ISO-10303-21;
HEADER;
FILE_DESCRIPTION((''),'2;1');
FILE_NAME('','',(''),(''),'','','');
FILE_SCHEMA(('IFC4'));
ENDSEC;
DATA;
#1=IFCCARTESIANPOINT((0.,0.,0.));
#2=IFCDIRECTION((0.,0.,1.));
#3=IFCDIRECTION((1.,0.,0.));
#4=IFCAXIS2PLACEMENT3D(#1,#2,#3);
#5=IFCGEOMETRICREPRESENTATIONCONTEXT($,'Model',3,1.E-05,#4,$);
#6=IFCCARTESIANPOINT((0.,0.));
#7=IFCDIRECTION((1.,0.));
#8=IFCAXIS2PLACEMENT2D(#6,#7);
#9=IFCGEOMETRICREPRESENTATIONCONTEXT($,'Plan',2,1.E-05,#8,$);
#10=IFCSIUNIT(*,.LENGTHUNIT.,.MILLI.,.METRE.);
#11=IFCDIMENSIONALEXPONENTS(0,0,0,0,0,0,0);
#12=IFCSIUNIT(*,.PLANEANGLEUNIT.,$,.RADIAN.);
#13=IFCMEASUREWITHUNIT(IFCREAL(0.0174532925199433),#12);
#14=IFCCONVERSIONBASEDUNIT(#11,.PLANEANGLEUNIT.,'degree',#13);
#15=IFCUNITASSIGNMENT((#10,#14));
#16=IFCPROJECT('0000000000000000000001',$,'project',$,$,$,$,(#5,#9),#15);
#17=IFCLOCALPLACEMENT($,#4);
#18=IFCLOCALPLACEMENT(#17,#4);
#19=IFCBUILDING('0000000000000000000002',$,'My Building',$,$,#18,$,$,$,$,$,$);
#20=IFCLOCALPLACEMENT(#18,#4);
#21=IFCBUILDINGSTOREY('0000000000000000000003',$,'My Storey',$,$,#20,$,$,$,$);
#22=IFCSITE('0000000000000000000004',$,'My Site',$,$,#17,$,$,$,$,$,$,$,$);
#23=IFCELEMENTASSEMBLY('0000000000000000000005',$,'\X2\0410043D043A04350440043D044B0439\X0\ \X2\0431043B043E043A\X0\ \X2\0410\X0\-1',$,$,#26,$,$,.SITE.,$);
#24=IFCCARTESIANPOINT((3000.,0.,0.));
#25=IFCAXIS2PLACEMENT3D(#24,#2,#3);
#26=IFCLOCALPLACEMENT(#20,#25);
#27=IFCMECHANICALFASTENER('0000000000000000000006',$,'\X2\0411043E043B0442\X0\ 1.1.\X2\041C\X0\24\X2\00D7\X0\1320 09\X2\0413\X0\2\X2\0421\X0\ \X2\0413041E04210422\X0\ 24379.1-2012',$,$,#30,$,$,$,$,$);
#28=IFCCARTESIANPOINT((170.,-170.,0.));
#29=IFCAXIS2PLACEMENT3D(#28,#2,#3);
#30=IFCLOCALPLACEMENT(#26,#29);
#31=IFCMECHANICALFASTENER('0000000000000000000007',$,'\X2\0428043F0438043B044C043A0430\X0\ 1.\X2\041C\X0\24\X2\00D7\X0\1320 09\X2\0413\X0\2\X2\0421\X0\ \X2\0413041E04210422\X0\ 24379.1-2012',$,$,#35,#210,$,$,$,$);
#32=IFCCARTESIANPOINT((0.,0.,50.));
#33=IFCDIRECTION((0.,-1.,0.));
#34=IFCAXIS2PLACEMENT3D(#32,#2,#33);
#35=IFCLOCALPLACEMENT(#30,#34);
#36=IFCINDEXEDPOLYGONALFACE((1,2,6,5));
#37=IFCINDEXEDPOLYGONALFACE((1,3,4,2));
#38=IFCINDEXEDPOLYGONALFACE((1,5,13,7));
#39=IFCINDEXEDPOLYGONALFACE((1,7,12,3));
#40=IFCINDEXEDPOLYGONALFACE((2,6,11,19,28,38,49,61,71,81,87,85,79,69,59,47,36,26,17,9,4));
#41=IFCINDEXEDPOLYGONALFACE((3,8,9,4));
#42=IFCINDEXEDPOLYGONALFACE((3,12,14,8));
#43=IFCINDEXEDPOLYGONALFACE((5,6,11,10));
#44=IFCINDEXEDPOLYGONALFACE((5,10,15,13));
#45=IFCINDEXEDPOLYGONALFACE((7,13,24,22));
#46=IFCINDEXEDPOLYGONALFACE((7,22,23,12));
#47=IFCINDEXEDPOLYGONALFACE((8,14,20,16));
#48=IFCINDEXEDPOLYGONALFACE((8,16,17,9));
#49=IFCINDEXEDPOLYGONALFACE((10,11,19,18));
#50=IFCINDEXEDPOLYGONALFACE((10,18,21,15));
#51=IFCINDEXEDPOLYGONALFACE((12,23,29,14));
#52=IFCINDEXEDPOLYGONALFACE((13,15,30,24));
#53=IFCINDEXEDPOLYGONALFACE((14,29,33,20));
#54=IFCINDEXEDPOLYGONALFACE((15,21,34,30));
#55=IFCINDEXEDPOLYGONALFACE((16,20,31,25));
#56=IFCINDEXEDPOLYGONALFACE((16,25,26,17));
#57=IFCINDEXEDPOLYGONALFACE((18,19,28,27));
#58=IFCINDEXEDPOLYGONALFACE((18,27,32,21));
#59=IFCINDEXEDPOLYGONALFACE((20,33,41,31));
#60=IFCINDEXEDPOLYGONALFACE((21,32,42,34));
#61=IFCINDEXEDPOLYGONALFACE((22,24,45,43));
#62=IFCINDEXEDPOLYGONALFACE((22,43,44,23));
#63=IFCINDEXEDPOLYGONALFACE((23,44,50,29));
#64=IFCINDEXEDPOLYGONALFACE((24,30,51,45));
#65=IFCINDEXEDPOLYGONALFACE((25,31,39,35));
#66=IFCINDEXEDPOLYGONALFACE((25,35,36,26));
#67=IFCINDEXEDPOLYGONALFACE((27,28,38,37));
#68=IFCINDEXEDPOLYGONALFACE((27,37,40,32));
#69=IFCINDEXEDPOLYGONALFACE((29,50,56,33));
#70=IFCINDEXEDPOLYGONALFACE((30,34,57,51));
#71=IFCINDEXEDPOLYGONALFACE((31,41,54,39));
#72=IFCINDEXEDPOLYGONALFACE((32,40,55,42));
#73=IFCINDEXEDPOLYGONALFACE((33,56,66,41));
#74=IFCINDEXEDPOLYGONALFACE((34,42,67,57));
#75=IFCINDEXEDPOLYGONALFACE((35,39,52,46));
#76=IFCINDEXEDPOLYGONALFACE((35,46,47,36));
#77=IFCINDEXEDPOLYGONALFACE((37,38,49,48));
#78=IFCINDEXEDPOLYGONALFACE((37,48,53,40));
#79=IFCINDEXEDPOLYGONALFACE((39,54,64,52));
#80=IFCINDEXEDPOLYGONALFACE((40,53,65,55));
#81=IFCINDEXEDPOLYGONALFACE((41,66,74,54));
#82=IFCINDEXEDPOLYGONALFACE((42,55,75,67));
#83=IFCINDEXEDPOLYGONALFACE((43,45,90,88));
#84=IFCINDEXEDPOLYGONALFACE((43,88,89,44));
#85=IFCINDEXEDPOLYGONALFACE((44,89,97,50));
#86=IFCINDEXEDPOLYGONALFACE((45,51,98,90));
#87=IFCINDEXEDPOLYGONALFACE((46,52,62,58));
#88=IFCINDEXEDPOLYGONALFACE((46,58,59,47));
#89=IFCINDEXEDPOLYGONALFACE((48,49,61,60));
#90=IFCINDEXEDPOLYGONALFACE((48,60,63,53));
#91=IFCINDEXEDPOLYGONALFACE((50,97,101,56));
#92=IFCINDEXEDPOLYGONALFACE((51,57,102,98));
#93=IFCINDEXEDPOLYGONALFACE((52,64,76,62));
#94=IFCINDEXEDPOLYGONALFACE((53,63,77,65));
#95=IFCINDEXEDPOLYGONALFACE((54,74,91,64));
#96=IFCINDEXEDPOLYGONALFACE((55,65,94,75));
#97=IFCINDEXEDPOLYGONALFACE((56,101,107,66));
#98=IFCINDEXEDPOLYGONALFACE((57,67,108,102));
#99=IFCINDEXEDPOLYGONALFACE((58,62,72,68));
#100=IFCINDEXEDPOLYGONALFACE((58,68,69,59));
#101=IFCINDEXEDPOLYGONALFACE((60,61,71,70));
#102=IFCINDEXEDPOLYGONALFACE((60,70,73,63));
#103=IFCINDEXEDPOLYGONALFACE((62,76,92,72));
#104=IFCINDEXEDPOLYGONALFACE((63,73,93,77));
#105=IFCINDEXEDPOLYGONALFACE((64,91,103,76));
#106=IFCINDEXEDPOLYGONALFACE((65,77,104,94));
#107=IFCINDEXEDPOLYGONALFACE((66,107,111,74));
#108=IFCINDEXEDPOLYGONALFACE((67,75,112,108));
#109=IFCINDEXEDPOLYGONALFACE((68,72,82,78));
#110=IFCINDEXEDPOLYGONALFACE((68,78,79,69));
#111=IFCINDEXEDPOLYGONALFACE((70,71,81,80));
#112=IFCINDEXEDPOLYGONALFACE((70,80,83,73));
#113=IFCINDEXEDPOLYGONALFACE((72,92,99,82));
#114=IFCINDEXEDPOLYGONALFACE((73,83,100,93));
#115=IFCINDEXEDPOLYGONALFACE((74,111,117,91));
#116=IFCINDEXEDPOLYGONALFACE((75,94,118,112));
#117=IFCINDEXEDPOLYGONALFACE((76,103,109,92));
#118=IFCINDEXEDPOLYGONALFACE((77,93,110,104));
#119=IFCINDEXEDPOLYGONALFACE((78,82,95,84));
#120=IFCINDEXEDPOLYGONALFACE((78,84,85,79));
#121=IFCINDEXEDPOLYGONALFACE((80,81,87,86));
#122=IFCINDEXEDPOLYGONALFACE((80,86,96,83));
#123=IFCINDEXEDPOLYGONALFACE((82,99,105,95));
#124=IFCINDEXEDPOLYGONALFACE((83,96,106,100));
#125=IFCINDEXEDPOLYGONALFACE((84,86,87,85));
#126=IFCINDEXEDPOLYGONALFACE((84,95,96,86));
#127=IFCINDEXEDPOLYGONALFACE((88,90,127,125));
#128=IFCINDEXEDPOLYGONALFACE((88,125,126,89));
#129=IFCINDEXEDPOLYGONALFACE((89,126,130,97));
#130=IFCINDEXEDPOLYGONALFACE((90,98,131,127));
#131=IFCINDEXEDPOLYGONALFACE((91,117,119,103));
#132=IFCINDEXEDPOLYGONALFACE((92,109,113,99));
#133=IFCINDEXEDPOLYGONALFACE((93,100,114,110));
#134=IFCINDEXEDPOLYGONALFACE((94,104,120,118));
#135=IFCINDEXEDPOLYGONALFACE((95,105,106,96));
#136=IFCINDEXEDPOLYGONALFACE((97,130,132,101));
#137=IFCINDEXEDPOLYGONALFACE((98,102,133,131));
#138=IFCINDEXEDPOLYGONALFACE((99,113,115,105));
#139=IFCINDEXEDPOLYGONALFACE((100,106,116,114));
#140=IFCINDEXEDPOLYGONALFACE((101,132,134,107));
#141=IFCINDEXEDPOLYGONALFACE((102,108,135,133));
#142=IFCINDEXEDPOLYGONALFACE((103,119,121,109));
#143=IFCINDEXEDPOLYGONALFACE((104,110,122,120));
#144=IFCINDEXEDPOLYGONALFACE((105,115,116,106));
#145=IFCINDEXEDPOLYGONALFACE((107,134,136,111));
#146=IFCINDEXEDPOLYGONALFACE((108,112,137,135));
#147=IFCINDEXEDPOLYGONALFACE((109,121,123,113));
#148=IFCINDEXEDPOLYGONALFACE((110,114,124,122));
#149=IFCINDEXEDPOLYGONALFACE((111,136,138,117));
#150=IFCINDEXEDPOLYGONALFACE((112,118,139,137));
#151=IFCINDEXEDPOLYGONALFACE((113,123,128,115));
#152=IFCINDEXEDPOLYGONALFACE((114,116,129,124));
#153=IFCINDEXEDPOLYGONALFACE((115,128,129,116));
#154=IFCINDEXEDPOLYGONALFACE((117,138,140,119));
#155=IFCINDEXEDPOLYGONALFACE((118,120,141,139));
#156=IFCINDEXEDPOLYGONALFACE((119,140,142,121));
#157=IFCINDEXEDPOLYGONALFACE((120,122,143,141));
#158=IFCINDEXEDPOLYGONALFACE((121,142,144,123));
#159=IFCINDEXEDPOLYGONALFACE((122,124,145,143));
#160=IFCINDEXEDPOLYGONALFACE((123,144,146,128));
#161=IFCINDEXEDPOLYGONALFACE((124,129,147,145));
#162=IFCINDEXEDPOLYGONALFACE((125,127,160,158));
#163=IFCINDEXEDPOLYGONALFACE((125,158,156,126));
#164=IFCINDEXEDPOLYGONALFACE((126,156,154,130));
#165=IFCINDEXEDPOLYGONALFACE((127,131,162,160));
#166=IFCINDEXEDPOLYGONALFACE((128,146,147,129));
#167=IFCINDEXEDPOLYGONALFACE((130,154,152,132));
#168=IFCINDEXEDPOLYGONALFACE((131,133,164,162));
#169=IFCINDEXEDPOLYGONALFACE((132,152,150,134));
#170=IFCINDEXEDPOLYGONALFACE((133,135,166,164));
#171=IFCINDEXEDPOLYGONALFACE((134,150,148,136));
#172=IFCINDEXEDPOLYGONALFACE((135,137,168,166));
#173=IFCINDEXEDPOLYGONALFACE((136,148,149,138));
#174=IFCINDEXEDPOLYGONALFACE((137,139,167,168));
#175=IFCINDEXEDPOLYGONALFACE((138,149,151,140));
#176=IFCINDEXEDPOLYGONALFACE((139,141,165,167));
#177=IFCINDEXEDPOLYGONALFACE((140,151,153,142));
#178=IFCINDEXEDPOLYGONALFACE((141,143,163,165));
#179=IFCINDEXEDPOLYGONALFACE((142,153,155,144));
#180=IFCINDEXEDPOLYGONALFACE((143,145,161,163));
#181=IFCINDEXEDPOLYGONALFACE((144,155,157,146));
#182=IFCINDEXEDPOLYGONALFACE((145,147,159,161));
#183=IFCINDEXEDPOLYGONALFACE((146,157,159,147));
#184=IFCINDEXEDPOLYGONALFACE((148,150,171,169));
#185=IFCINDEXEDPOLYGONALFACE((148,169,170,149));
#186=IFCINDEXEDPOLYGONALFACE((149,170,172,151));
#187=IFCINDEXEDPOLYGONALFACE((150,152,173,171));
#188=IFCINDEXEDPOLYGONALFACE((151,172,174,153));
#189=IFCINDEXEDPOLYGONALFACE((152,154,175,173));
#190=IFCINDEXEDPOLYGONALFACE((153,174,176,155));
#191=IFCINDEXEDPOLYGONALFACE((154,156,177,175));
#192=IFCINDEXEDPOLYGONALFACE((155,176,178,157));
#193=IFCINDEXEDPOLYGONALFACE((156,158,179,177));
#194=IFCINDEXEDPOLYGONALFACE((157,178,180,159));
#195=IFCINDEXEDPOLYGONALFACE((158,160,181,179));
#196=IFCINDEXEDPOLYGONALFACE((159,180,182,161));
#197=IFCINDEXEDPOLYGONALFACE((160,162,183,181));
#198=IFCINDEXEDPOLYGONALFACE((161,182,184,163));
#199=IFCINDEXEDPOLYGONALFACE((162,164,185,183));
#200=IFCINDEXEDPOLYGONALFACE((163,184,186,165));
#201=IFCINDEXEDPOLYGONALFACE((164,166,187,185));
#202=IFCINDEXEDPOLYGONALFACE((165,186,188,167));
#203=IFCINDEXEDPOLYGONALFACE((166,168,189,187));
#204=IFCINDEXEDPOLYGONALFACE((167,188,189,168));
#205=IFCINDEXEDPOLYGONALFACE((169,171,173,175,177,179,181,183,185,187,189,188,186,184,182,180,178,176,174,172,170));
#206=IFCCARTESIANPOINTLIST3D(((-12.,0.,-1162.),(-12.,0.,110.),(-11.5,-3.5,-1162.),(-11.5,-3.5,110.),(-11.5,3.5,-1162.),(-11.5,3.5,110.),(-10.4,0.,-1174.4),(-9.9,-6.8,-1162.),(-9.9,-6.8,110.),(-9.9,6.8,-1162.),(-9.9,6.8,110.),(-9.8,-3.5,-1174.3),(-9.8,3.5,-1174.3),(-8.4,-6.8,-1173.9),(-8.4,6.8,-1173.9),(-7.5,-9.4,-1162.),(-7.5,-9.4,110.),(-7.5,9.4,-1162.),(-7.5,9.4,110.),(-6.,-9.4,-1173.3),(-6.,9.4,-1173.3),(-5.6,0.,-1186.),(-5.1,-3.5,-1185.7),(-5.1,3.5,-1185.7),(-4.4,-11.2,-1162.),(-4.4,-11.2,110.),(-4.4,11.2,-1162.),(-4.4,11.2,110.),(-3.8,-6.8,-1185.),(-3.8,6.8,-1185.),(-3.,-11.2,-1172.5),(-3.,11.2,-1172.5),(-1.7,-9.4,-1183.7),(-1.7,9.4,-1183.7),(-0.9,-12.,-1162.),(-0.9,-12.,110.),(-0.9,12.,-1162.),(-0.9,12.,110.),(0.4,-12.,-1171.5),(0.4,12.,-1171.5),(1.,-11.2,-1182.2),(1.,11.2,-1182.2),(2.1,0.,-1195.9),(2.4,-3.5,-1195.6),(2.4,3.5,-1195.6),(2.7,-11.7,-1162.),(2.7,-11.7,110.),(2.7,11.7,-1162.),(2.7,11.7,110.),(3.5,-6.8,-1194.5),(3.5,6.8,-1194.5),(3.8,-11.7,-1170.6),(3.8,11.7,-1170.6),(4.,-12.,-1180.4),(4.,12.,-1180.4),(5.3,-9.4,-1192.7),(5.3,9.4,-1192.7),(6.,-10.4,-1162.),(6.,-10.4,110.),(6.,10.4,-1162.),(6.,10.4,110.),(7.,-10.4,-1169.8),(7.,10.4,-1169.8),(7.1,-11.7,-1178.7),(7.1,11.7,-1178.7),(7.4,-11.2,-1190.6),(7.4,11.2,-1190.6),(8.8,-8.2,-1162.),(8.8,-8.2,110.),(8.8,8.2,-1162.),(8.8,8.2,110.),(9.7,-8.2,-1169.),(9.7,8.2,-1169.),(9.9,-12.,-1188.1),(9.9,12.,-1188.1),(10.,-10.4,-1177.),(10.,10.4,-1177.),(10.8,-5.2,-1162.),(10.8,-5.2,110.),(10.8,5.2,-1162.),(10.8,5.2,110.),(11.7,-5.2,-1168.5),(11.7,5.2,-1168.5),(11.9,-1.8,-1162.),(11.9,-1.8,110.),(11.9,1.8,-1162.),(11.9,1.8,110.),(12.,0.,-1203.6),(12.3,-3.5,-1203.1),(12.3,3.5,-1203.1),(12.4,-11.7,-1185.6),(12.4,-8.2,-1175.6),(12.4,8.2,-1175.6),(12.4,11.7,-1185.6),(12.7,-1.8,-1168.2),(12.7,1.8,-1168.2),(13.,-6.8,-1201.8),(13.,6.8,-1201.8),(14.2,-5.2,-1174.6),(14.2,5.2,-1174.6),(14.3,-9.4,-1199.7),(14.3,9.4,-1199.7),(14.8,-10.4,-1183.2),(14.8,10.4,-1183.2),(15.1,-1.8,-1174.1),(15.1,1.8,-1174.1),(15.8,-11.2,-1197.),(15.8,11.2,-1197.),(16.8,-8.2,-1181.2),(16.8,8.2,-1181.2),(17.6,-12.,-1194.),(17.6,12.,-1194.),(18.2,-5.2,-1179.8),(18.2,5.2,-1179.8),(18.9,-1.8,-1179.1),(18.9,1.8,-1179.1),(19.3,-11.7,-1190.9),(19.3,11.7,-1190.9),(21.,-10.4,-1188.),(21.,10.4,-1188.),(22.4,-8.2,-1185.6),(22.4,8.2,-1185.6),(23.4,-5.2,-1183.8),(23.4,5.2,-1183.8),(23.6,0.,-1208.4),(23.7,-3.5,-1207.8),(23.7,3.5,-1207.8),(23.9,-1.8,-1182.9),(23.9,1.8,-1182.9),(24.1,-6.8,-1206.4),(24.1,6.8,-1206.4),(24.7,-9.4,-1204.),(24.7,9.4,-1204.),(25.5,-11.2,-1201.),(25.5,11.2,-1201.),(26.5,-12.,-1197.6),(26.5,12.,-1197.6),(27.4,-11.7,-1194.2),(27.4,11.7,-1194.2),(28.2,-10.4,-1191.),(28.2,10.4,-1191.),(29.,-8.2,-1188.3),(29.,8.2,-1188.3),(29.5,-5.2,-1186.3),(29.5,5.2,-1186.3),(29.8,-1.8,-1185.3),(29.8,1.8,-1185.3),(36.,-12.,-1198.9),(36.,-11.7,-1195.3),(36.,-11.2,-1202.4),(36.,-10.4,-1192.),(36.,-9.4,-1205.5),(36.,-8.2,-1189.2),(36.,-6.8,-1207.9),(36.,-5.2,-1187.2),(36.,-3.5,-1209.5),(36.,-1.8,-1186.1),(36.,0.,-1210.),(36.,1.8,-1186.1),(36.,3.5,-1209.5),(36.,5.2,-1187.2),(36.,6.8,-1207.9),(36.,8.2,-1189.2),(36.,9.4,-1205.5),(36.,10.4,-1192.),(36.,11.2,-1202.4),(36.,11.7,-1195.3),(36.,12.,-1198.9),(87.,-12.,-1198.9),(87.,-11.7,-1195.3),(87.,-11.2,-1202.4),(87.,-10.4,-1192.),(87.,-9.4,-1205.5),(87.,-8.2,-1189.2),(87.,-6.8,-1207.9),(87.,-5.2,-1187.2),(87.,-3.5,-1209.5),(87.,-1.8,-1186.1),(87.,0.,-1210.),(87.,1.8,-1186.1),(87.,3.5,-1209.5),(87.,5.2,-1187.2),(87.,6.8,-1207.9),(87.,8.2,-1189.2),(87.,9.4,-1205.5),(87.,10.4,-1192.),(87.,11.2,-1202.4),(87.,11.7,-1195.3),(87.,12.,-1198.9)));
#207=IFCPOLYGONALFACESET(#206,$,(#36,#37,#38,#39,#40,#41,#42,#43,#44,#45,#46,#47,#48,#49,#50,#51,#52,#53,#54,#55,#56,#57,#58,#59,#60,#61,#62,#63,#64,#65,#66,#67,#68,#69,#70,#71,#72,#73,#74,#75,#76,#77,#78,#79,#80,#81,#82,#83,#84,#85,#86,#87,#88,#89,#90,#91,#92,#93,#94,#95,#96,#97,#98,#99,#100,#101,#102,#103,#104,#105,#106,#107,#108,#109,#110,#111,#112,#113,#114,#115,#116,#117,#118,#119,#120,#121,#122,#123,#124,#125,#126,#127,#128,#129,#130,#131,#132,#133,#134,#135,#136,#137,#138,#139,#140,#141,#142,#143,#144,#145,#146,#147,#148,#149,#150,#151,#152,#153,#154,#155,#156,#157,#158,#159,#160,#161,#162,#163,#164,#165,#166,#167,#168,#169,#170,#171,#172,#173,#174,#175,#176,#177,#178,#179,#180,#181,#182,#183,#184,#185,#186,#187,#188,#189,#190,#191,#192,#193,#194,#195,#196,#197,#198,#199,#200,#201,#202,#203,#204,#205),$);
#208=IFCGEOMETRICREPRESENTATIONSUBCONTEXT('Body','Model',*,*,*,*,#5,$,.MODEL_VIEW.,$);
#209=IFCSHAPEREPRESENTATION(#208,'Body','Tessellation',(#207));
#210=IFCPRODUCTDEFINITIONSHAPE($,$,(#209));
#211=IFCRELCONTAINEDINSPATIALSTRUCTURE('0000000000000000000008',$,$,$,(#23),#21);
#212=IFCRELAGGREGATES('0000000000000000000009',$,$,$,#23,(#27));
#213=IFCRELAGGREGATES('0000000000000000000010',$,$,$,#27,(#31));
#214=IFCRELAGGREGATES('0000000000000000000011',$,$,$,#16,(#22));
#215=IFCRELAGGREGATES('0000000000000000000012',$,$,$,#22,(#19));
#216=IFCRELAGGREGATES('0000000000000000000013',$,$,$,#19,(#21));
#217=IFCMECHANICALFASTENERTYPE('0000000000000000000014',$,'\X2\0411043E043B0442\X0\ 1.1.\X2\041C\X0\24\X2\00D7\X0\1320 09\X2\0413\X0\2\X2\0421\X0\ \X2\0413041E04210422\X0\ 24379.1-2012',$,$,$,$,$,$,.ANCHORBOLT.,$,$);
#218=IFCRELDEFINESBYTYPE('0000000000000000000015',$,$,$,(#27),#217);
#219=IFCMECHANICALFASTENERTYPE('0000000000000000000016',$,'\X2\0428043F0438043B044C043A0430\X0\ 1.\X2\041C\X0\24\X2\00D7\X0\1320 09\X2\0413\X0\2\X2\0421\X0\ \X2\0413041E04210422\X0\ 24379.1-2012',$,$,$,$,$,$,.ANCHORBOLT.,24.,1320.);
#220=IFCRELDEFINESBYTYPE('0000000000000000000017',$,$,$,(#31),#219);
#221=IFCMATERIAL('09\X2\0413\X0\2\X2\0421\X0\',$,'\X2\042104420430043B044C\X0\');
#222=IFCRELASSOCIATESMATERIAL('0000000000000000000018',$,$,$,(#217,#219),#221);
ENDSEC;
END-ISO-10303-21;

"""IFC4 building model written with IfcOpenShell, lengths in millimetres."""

from ifc_helpers import new_model, entity, si_unit, converted_unit, frame, origin_with_axes, origin_2d_with_axis, place, context, subcontext, project, spatial, source, transform, mapped, material, type_object, type_shapes, element, aggregate, save


model = new_model("IFC4")

# Units and contexts
model_context = context("Model", 3, precision=1e-05, world=origin_with_axes())
plan_context = context("Plan", 2, precision=1e-05, world=origin_2d_with_axis())
body_context = subcontext(model_context, "Body", "Model", "MODEL_VIEW")
ifc_project = project(units=[si_unit("LENGTHUNIT", "METRE", prefix="MILLI"), converted_unit("PLANEANGLEUNIT", "degree", entity("IfcReal", 0.0174532925199433), si_unit("PLANEANGLEUNIT", "RADIAN"), dimensions=[0, 0, 0, 0, 0, 0, 0])], contexts=[model_context, plan_context])

# Site, building, storey
site_placement = place(None, origin_with_axes())
site = spatial("IfcSite", under=ifc_project, at=site_placement, Name="My Site")
building_placement = place(site_placement, origin_with_axes())
building = spatial("IfcBuilding", under=site, at=building_placement, Name="My Building")
storey_placement = place(building_placement, origin_with_axes())
storey = spatial("IfcBuildingStorey", under=building, at=storey_placement, Name="My Storey")

# Element assembly
placement_1 = place(storey_placement, frame((3000.0, 0.0, 0.0), z_axis=(0.0, 0.0, 1.0), x_axis=(1.0, 0.0, 0.0)))
assembly_1 = element("IfcElementAssembly", 1, at=placement_1, inside=storey, Name="Анкерный блок А-1", AssemblyPlace="SITE")

# Shared definitions
ifc_material_1 = material(Name="09Г2С", Category="Сталь")
mechanical_fastener_type_1 = type_object("IfcMechanicalFastenerType", Name="Болт 1.1.М24×1320 09Г2С ГОСТ 24379.1-2012", PredefinedType="ANCHORBOLT", material=ifc_material_1)
mechanical_fastener_type_2 = type_object("IfcMechanicalFastenerType", Name="Шпилька 1.М24×1320 09Г2С ГОСТ 24379.1-2012", NominalDiameter=24.0, NominalLength=1320.0, PredefinedType="ANCHORBOLT", material=ifc_material_1)
shared_shape_1 = source(frame((0.0, 0.0, 110.0), z_axis=(0.0, 0.0, 1.0), x_axis=(1.0, 0.0, 0.0)), body_context, "Body", "AdvancedSweptSolid", [
    entity("IfcSweptDiskSolid", entity("IfcIndexedPolyCurve", entity("IfcCartesianPointList3D", [[0.0, 0.0, 0.0], [0.0, 0.0, -1272.0], [10.5, 0.0, -1297.5], [36.0, 0.0, -1308.0], [87.0, 0.0, -1308.0]]), [entity("IfcLineIndex", [1, 2]), entity("IfcArcIndex", [2, 3, 4]), entity("IfcLineIndex", [4, 5])]), 12.0),
])
type_shapes(mechanical_fastener_type_2, [shared_shape_1])

# Mechanical fasteners
mechanical_fastener_1_placement = place(placement_1, frame((170.0, -170.0, 0.0), z_axis=(0.0, 0.0, 1.0), x_axis=(1.0, 0.0, 0.0)))
mechanical_fastener_1 = element("IfcMechanicalFastener", 2, at=mechanical_fastener_1_placement, type_object=mechanical_fastener_type_1, Name="Болт 1.1.М24×1320 09Г2С ГОСТ 24379.1-2012")
mechanical_fastener_2_placement = place(mechanical_fastener_1_placement, frame((0.0, 0.0, 50.0), z_axis=(0.0, 0.0, 1.0), x_axis=(0.0, -1.0, 0.0)))
mechanical_fastener_2 = element("IfcMechanicalFastener", 3, at=mechanical_fastener_2_placement, type_object=mechanical_fastener_type_2, Name="Шпилька 1.М24×1320 09Г2С ГОСТ 24379.1-2012", context=body_context, shape_type="MappedRepresentation", body=[
    mapped(shared_shape_1, transform((0.0, 0.0, 0.0), x_axis=(1.0, 0.0, 0.0), y_axis=(0.0, 1.0, 0.0), z_axis=(0.0, 0.0, 1.0), scale=1.0)),
])

aggregate(assembly_1, [mechanical_fastener_1])
aggregate(mechanical_fastener_1, [mechanical_fastener_2])

save(model, "model.ifc")
